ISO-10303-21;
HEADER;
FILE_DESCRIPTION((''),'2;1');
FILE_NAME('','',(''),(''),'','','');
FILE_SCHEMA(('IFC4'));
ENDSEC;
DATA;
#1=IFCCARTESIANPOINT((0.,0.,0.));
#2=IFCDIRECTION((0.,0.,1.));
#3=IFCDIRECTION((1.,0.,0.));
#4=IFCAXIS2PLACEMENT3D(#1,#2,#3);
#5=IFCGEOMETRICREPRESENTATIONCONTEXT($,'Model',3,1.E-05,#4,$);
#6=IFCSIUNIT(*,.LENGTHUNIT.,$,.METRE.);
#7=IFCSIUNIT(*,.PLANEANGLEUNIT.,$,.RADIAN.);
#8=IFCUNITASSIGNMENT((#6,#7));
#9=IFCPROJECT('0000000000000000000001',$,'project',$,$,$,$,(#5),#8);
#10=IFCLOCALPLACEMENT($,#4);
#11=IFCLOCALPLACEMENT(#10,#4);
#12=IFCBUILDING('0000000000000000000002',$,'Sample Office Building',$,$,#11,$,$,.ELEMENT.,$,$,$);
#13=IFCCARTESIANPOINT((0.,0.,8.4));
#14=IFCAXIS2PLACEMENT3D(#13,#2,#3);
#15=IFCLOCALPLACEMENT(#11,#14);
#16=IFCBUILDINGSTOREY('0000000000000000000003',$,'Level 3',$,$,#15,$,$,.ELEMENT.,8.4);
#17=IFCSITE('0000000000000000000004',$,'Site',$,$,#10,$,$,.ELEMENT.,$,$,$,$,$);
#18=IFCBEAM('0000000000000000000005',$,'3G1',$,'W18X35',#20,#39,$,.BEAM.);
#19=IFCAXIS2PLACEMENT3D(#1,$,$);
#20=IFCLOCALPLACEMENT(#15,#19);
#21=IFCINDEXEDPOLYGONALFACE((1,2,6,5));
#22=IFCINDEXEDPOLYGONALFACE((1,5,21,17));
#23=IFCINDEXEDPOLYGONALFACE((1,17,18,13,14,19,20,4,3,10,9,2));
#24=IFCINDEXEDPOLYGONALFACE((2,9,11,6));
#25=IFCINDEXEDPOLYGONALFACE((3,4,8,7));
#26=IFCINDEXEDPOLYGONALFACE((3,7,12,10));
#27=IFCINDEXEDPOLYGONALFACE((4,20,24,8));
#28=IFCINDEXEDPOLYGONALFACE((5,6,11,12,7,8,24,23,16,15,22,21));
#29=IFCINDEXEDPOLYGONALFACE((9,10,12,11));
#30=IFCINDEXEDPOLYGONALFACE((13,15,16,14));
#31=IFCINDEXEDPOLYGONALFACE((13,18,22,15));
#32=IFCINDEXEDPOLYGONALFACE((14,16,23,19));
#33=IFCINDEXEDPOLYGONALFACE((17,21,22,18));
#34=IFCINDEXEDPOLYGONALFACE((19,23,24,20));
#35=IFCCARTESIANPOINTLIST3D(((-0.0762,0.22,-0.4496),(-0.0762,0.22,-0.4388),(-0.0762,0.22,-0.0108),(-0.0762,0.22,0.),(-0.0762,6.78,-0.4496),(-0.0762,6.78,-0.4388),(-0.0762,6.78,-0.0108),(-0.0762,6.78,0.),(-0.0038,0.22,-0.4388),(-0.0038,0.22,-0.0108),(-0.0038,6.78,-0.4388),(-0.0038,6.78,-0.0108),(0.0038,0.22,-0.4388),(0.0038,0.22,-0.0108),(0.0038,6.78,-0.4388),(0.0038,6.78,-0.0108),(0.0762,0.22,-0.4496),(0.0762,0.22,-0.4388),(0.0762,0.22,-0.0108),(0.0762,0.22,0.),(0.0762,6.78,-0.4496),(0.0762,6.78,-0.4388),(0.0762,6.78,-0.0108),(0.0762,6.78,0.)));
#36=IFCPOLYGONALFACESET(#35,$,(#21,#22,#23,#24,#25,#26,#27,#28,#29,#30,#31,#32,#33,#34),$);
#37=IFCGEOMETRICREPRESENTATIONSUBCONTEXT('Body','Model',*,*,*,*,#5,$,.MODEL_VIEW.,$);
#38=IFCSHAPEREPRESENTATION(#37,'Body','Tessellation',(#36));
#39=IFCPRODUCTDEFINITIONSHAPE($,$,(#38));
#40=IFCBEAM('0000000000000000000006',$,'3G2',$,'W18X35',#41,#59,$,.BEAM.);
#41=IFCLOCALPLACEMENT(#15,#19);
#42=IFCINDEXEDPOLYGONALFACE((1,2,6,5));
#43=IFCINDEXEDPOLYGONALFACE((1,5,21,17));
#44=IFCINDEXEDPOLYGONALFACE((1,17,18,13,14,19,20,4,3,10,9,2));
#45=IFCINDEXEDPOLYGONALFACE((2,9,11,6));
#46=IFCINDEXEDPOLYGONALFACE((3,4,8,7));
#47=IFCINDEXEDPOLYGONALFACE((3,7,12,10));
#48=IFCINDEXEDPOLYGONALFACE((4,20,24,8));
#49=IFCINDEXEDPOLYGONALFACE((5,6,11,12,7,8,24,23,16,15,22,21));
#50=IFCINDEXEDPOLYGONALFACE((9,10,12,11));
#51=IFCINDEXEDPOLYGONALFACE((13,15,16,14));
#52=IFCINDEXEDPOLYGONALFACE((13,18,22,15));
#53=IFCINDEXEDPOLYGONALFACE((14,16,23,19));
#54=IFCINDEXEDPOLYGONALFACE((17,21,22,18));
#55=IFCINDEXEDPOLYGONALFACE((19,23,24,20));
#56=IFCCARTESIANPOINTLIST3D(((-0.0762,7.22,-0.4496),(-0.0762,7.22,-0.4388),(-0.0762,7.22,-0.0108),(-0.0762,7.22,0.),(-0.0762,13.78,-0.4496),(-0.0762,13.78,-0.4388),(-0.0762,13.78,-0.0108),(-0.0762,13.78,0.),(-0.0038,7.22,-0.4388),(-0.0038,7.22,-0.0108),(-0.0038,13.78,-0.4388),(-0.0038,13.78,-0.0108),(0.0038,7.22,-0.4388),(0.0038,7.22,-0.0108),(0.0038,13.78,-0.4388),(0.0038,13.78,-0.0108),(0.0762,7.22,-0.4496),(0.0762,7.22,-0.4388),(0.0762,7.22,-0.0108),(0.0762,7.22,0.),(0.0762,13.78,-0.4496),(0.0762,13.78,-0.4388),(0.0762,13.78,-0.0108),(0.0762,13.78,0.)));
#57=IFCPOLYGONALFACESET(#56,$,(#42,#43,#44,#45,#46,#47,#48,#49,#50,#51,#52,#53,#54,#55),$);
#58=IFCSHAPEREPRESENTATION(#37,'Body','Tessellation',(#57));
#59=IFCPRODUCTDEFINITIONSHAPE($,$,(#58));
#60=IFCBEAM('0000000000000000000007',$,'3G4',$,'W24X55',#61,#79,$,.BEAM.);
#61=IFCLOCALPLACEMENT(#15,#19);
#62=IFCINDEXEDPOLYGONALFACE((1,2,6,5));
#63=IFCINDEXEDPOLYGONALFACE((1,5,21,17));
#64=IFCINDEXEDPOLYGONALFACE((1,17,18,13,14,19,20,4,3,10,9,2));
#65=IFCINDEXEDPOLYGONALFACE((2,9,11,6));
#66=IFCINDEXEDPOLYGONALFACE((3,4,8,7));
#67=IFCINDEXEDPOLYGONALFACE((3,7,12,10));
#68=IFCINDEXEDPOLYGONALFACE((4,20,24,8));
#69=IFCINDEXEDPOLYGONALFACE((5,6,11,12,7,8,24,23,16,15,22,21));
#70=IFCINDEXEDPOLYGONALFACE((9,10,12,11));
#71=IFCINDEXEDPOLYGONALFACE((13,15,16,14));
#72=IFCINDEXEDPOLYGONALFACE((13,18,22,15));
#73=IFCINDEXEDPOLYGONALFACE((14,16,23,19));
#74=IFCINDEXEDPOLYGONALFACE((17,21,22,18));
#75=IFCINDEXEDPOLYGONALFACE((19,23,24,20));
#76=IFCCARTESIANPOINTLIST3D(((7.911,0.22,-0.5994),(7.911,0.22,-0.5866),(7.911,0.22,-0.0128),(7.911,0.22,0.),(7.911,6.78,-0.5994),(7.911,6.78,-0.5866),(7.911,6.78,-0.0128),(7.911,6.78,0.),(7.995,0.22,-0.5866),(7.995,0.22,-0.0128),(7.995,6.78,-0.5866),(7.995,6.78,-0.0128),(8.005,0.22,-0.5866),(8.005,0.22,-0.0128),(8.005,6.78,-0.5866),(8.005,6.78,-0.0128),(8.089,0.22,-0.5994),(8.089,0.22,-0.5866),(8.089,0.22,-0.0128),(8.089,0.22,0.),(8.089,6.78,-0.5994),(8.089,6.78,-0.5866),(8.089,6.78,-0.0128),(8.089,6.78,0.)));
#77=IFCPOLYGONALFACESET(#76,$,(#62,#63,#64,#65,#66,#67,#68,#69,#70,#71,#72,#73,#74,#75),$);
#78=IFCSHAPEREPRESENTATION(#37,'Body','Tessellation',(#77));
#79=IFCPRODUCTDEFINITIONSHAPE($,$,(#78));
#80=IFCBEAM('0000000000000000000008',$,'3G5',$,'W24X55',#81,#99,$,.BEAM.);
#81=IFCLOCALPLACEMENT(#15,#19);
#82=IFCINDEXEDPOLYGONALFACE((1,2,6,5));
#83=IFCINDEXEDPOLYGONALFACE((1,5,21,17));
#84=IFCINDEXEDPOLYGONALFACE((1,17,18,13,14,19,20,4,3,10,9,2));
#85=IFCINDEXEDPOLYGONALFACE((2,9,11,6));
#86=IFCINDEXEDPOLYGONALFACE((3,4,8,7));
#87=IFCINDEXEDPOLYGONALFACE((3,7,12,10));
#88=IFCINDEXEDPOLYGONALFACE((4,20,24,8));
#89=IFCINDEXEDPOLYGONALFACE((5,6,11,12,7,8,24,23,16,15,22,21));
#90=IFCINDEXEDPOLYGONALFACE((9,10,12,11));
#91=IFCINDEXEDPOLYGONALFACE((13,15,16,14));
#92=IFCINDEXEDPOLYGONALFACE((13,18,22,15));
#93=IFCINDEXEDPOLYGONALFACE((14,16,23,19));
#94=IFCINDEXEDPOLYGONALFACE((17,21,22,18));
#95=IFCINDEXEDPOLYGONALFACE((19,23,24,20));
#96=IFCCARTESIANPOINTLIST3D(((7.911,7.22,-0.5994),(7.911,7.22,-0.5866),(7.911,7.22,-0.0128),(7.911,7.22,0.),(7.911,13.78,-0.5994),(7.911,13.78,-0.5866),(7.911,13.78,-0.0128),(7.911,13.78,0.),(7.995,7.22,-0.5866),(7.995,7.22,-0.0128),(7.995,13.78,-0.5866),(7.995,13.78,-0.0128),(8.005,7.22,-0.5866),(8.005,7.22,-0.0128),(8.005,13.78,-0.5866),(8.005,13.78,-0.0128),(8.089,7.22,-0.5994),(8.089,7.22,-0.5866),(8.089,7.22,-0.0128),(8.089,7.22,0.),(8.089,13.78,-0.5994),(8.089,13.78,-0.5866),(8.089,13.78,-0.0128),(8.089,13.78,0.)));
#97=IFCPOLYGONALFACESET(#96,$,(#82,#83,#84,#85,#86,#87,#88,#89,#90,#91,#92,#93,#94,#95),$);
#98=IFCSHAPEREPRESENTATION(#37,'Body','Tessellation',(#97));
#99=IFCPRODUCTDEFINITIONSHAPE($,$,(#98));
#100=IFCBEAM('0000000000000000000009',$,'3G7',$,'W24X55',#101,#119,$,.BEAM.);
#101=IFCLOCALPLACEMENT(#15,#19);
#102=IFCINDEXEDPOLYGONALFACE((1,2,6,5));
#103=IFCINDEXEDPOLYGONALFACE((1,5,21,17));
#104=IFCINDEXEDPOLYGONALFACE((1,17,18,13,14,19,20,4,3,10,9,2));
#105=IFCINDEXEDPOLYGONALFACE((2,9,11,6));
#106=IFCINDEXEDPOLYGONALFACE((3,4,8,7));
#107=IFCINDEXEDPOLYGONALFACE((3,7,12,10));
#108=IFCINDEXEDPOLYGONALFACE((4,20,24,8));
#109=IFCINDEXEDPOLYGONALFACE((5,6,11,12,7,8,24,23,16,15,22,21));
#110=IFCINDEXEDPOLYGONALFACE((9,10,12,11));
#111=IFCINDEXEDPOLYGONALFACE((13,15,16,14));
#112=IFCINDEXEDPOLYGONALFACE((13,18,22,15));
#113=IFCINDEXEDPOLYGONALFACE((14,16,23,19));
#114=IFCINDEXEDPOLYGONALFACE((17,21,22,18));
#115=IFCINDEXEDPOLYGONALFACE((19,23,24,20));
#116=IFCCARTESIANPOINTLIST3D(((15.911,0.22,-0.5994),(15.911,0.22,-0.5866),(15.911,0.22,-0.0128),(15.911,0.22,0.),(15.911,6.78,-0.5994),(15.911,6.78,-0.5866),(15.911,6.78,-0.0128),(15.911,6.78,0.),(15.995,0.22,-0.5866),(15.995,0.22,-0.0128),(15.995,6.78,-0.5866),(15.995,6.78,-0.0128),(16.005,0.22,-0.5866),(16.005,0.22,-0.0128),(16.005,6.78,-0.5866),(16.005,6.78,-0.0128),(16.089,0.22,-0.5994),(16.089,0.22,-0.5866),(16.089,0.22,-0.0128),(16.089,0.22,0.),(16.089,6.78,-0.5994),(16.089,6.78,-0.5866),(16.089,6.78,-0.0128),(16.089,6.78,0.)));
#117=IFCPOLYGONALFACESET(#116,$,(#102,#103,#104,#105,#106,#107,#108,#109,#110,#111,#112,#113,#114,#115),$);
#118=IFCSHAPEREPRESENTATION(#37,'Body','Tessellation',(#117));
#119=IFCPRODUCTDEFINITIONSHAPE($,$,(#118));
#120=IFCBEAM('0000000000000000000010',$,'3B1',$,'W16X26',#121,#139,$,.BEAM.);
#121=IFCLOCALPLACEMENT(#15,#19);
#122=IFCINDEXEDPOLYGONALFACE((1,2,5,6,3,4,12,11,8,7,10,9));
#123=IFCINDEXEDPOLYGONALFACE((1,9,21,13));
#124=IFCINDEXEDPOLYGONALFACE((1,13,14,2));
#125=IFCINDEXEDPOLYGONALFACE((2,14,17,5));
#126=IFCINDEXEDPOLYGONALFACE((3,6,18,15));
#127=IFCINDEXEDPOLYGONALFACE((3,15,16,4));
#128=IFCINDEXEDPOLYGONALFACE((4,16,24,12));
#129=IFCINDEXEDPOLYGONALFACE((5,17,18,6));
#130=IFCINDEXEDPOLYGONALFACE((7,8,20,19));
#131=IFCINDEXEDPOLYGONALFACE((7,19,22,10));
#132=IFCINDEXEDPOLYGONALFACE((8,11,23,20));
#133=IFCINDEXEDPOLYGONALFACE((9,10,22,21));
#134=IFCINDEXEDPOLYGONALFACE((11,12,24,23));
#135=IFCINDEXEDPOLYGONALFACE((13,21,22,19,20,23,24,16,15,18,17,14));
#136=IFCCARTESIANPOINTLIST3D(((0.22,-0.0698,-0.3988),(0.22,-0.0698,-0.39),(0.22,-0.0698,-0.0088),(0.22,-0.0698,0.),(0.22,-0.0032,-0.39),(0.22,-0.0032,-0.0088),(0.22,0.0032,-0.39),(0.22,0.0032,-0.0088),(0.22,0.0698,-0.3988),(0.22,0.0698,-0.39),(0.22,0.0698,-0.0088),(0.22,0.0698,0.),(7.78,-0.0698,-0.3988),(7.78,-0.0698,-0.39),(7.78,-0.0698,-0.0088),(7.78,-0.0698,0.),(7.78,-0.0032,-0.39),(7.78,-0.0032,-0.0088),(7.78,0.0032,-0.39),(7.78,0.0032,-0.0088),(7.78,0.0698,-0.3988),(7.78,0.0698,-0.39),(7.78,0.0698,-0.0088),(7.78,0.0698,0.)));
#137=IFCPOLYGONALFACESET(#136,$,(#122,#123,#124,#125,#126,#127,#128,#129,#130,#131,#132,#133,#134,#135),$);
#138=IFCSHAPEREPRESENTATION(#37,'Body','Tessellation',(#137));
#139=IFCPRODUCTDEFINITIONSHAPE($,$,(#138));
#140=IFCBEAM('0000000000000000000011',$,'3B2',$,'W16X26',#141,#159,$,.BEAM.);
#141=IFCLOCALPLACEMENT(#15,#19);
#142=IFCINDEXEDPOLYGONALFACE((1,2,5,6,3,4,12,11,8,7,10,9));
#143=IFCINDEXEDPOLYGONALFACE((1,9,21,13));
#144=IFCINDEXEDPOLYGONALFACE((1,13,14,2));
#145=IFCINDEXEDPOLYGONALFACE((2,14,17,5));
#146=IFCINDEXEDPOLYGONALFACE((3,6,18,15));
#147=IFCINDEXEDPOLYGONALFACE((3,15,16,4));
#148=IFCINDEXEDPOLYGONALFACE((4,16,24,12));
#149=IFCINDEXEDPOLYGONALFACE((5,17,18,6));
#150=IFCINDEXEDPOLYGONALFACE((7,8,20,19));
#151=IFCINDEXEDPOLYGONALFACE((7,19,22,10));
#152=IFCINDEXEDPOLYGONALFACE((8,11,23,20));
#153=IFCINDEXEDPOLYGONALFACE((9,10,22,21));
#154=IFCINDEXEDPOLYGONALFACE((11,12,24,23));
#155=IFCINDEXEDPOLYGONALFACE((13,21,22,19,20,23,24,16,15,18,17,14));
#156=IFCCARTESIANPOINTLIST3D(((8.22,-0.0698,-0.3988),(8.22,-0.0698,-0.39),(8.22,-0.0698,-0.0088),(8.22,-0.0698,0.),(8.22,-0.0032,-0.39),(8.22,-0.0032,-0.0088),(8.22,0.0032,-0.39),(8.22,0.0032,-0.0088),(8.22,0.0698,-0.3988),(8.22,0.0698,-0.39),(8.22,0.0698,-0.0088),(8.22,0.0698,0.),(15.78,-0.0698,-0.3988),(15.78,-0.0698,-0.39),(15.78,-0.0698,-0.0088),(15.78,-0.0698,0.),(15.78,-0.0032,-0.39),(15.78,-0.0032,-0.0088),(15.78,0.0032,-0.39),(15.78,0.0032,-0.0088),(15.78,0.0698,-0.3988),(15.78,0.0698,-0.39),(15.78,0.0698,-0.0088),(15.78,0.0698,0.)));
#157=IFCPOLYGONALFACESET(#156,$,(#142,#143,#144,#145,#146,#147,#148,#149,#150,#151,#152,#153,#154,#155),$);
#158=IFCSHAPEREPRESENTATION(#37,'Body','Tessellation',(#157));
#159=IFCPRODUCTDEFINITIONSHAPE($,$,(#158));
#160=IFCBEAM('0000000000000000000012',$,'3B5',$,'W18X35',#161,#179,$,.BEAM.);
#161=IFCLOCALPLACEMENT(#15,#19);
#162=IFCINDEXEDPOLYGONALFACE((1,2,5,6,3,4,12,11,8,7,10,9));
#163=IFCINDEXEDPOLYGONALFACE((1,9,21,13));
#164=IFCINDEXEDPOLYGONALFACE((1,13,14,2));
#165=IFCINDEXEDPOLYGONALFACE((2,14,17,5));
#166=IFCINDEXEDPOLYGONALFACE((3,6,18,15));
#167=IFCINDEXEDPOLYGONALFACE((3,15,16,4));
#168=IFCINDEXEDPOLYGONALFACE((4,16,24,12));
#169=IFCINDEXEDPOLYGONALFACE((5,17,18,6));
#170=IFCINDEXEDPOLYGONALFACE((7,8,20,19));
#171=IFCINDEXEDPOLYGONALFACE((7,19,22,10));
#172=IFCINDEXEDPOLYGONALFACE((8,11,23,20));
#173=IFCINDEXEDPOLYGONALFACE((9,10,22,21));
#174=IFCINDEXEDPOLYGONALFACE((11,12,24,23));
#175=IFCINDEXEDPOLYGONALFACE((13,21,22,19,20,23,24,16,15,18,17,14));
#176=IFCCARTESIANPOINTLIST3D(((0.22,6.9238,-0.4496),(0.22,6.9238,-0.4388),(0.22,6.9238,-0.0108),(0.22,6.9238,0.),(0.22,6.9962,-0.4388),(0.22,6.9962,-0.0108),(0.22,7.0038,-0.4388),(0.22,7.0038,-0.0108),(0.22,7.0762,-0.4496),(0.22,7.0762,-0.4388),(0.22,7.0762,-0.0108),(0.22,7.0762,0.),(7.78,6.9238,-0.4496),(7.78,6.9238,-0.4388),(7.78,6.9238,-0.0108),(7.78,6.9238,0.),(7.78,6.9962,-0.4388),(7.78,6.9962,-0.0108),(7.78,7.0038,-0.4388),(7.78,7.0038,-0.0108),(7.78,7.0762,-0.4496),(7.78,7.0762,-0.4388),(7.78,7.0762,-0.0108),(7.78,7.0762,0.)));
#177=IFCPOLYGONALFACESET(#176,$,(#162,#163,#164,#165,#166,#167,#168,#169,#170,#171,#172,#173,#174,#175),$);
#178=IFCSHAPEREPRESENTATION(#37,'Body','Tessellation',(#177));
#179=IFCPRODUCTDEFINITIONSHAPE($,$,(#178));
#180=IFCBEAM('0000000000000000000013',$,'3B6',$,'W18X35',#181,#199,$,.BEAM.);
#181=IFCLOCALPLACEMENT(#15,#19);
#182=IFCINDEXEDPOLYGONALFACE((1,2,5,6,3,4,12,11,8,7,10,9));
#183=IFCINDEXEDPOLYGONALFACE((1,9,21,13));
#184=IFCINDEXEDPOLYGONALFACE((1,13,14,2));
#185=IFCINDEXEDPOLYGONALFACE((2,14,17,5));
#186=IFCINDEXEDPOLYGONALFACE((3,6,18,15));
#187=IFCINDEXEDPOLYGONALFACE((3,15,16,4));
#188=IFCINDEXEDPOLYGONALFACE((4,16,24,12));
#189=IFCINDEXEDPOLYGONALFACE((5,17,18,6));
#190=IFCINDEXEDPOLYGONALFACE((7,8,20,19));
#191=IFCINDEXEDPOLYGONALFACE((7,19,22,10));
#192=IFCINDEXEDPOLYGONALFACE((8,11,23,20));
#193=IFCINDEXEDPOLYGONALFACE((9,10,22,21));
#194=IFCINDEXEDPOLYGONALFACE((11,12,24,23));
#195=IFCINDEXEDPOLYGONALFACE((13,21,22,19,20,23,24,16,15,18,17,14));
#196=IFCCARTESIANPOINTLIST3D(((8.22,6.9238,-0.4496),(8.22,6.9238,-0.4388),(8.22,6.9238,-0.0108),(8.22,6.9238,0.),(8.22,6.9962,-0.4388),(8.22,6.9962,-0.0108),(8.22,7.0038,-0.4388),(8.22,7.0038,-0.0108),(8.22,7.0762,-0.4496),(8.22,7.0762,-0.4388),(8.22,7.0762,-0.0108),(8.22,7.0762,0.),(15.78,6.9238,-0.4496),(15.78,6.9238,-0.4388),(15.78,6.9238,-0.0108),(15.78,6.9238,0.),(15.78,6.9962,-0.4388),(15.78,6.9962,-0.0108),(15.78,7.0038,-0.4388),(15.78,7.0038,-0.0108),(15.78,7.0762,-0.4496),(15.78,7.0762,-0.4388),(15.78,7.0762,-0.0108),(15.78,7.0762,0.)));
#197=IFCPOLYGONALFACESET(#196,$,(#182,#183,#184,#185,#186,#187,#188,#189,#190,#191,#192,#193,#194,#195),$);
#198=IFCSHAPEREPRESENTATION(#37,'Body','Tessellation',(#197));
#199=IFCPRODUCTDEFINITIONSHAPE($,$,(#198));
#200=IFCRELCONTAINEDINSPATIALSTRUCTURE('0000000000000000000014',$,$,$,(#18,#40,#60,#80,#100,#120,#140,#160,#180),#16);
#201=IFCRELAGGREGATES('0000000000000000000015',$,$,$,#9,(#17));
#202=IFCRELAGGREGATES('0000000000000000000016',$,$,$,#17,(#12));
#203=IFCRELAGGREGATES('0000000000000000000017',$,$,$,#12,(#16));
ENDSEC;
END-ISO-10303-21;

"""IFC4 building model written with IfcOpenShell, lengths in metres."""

from ifc_helpers import new_model, si_unit, frame, origin_with_axes, place, context, subcontext, project, spatial, i_section, extrude, element, save


model = new_model("IFC4")

# Units and contexts
model_context = context("Model", 3, precision=1e-05, world=origin_with_axes())
body_context = subcontext(model_context, "Body", "Model", "MODEL_VIEW")
ifc_project = project(units=[si_unit("LENGTHUNIT", "METRE"), si_unit("PLANEANGLEUNIT", "RADIAN")], contexts=[model_context])

# Site, building, storey
site_placement = place(None, origin_with_axes())
site = spatial("IfcSite", under=ifc_project, at=site_placement, Name="Site", CompositionType="ELEMENT")
building_placement = place(site_placement, origin_with_axes())
building = spatial("IfcBuilding", under=site, at=building_placement, Name="Sample Office Building", CompositionType="ELEMENT")
storey_placement = place(building_placement, frame((0.0, 0.0, 8.4), z_axis=(0.0, 0.0, 1.0), x_axis=(1.0, 0.0, 0.0)))
storey = spatial("IfcBuildingStorey", under=building, at=storey_placement, Name="Level 3", CompositionType="ELEMENT", Elevation=8.4)

# Beams
beam_1_placement = place(None, frame((0.0, 0.22, 8.1752), z_axis=(0.0, 1.0, 0.0), x_axis=(-1.0, 0.0, 0.0)))
element("IfcBeam", 1, at=beam_1_placement, inside=storey, Name="3G1", ObjectType="W18X35", PredefinedType="BEAM", context=body_context, shape_type="SweptSolid", body=[
    extrude(i_section(OverallWidth=0.1524, OverallDepth=0.4496, WebThickness=0.0076, FlangeThickness=0.0108), None, (0.0, 0.0, 1.0), 6.56),
])
beam_2_placement = place(None, frame((0.0, 7.22, 8.1752), z_axis=(0.0, 1.0, 0.0), x_axis=(-1.0, 0.0, 0.0)))
element("IfcBeam", 2, at=beam_2_placement, inside=storey, Name="3G2", ObjectType="W18X35", PredefinedType="BEAM", context=body_context, shape_type="SweptSolid", body=[
    extrude(i_section(OverallWidth=0.1524, OverallDepth=0.4496, WebThickness=0.0076, FlangeThickness=0.0108), None, (0.0, 0.0, 1.0), 6.56),
])
beam_3_placement = place(None, frame((8.0, 0.22, 8.1003), z_axis=(0.0, 1.0, 0.0), x_axis=(-1.0, 0.0, 0.0)))
element("IfcBeam", 3, at=beam_3_placement, inside=storey, Name="3G4", ObjectType="W24X55", PredefinedType="BEAM", context=body_context, shape_type="SweptSolid", body=[
    extrude(i_section(OverallWidth=0.1781, OverallDepth=0.5994, WebThickness=0.01, FlangeThickness=0.0128), None, (0.0, 0.0, 1.0), 6.56),
])
beam_4_placement = place(None, frame((8.0, 7.22, 8.1003), z_axis=(0.0, 1.0, 0.0), x_axis=(-1.0, 0.0, 0.0)))
element("IfcBeam", 4, at=beam_4_placement, inside=storey, Name="3G5", ObjectType="W24X55", PredefinedType="BEAM", context=body_context, shape_type="SweptSolid", body=[
    extrude(i_section(OverallWidth=0.1781, OverallDepth=0.5994, WebThickness=0.01, FlangeThickness=0.0128), None, (0.0, 0.0, 1.0), 6.56),
])
beam_5_placement = place(None, frame((16.0, 0.22, 8.1003), z_axis=(0.0, 1.0, 0.0), x_axis=(-1.0, 0.0, 0.0)))
element("IfcBeam", 5, at=beam_5_placement, inside=storey, Name="3G7", ObjectType="W24X55", PredefinedType="BEAM", context=body_context, shape_type="SweptSolid", body=[
    extrude(i_section(OverallWidth=0.1781, OverallDepth=0.5994, WebThickness=0.01, FlangeThickness=0.0128), None, (0.0, 0.0, 1.0), 6.56),
])
beam_6_placement = place(None, frame((0.22, 0.0, 8.2006), z_axis=(1.0, 0.0, 0.0), x_axis=(0.0, 1.0, 0.0)))
element("IfcBeam", 6, at=beam_6_placement, inside=storey, Name="3B1", ObjectType="W16X26", PredefinedType="BEAM", context=body_context, shape_type="SweptSolid", body=[
    extrude(i_section(OverallWidth=0.1397, OverallDepth=0.3988, WebThickness=0.0063, FlangeThickness=0.0088), None, (0.0, 0.0, 1.0), 7.56),
])
beam_7_placement = place(None, frame((8.22, 0.0, 8.2006), z_axis=(1.0, 0.0, 0.0), x_axis=(0.0, 1.0, 0.0)))
element("IfcBeam", 7, at=beam_7_placement, inside=storey, Name="3B2", ObjectType="W16X26", PredefinedType="BEAM", context=body_context, shape_type="SweptSolid", body=[
    extrude(i_section(OverallWidth=0.1397, OverallDepth=0.3988, WebThickness=0.0063, FlangeThickness=0.0088), None, (0.0, 0.0, 1.0), 7.56),
])
beam_8_placement = place(None, frame((0.22, 7.0, 8.1752), z_axis=(1.0, 0.0, 0.0), x_axis=(0.0, 1.0, 0.0)))
element("IfcBeam", 8, at=beam_8_placement, inside=storey, Name="3B5", ObjectType="W18X35", PredefinedType="BEAM", context=body_context, shape_type="SweptSolid", body=[
    extrude(i_section(OverallWidth=0.1524, OverallDepth=0.4496, WebThickness=0.0076, FlangeThickness=0.0108), None, (0.0, 0.0, 1.0), 7.56),
])
beam_9_placement = place(None, frame((8.22, 7.0, 8.1752), z_axis=(1.0, 0.0, 0.0), x_axis=(0.0, 1.0, 0.0)))
element("IfcBeam", 9, at=beam_9_placement, inside=storey, Name="3B6", ObjectType="W18X35", PredefinedType="BEAM", context=body_context, shape_type="SweptSolid", body=[
    extrude(i_section(OverallWidth=0.1524, OverallDepth=0.4496, WebThickness=0.0076, FlangeThickness=0.0108), None, (0.0, 0.0, 1.0), 7.56),
])

save(model, "model.ifc")
